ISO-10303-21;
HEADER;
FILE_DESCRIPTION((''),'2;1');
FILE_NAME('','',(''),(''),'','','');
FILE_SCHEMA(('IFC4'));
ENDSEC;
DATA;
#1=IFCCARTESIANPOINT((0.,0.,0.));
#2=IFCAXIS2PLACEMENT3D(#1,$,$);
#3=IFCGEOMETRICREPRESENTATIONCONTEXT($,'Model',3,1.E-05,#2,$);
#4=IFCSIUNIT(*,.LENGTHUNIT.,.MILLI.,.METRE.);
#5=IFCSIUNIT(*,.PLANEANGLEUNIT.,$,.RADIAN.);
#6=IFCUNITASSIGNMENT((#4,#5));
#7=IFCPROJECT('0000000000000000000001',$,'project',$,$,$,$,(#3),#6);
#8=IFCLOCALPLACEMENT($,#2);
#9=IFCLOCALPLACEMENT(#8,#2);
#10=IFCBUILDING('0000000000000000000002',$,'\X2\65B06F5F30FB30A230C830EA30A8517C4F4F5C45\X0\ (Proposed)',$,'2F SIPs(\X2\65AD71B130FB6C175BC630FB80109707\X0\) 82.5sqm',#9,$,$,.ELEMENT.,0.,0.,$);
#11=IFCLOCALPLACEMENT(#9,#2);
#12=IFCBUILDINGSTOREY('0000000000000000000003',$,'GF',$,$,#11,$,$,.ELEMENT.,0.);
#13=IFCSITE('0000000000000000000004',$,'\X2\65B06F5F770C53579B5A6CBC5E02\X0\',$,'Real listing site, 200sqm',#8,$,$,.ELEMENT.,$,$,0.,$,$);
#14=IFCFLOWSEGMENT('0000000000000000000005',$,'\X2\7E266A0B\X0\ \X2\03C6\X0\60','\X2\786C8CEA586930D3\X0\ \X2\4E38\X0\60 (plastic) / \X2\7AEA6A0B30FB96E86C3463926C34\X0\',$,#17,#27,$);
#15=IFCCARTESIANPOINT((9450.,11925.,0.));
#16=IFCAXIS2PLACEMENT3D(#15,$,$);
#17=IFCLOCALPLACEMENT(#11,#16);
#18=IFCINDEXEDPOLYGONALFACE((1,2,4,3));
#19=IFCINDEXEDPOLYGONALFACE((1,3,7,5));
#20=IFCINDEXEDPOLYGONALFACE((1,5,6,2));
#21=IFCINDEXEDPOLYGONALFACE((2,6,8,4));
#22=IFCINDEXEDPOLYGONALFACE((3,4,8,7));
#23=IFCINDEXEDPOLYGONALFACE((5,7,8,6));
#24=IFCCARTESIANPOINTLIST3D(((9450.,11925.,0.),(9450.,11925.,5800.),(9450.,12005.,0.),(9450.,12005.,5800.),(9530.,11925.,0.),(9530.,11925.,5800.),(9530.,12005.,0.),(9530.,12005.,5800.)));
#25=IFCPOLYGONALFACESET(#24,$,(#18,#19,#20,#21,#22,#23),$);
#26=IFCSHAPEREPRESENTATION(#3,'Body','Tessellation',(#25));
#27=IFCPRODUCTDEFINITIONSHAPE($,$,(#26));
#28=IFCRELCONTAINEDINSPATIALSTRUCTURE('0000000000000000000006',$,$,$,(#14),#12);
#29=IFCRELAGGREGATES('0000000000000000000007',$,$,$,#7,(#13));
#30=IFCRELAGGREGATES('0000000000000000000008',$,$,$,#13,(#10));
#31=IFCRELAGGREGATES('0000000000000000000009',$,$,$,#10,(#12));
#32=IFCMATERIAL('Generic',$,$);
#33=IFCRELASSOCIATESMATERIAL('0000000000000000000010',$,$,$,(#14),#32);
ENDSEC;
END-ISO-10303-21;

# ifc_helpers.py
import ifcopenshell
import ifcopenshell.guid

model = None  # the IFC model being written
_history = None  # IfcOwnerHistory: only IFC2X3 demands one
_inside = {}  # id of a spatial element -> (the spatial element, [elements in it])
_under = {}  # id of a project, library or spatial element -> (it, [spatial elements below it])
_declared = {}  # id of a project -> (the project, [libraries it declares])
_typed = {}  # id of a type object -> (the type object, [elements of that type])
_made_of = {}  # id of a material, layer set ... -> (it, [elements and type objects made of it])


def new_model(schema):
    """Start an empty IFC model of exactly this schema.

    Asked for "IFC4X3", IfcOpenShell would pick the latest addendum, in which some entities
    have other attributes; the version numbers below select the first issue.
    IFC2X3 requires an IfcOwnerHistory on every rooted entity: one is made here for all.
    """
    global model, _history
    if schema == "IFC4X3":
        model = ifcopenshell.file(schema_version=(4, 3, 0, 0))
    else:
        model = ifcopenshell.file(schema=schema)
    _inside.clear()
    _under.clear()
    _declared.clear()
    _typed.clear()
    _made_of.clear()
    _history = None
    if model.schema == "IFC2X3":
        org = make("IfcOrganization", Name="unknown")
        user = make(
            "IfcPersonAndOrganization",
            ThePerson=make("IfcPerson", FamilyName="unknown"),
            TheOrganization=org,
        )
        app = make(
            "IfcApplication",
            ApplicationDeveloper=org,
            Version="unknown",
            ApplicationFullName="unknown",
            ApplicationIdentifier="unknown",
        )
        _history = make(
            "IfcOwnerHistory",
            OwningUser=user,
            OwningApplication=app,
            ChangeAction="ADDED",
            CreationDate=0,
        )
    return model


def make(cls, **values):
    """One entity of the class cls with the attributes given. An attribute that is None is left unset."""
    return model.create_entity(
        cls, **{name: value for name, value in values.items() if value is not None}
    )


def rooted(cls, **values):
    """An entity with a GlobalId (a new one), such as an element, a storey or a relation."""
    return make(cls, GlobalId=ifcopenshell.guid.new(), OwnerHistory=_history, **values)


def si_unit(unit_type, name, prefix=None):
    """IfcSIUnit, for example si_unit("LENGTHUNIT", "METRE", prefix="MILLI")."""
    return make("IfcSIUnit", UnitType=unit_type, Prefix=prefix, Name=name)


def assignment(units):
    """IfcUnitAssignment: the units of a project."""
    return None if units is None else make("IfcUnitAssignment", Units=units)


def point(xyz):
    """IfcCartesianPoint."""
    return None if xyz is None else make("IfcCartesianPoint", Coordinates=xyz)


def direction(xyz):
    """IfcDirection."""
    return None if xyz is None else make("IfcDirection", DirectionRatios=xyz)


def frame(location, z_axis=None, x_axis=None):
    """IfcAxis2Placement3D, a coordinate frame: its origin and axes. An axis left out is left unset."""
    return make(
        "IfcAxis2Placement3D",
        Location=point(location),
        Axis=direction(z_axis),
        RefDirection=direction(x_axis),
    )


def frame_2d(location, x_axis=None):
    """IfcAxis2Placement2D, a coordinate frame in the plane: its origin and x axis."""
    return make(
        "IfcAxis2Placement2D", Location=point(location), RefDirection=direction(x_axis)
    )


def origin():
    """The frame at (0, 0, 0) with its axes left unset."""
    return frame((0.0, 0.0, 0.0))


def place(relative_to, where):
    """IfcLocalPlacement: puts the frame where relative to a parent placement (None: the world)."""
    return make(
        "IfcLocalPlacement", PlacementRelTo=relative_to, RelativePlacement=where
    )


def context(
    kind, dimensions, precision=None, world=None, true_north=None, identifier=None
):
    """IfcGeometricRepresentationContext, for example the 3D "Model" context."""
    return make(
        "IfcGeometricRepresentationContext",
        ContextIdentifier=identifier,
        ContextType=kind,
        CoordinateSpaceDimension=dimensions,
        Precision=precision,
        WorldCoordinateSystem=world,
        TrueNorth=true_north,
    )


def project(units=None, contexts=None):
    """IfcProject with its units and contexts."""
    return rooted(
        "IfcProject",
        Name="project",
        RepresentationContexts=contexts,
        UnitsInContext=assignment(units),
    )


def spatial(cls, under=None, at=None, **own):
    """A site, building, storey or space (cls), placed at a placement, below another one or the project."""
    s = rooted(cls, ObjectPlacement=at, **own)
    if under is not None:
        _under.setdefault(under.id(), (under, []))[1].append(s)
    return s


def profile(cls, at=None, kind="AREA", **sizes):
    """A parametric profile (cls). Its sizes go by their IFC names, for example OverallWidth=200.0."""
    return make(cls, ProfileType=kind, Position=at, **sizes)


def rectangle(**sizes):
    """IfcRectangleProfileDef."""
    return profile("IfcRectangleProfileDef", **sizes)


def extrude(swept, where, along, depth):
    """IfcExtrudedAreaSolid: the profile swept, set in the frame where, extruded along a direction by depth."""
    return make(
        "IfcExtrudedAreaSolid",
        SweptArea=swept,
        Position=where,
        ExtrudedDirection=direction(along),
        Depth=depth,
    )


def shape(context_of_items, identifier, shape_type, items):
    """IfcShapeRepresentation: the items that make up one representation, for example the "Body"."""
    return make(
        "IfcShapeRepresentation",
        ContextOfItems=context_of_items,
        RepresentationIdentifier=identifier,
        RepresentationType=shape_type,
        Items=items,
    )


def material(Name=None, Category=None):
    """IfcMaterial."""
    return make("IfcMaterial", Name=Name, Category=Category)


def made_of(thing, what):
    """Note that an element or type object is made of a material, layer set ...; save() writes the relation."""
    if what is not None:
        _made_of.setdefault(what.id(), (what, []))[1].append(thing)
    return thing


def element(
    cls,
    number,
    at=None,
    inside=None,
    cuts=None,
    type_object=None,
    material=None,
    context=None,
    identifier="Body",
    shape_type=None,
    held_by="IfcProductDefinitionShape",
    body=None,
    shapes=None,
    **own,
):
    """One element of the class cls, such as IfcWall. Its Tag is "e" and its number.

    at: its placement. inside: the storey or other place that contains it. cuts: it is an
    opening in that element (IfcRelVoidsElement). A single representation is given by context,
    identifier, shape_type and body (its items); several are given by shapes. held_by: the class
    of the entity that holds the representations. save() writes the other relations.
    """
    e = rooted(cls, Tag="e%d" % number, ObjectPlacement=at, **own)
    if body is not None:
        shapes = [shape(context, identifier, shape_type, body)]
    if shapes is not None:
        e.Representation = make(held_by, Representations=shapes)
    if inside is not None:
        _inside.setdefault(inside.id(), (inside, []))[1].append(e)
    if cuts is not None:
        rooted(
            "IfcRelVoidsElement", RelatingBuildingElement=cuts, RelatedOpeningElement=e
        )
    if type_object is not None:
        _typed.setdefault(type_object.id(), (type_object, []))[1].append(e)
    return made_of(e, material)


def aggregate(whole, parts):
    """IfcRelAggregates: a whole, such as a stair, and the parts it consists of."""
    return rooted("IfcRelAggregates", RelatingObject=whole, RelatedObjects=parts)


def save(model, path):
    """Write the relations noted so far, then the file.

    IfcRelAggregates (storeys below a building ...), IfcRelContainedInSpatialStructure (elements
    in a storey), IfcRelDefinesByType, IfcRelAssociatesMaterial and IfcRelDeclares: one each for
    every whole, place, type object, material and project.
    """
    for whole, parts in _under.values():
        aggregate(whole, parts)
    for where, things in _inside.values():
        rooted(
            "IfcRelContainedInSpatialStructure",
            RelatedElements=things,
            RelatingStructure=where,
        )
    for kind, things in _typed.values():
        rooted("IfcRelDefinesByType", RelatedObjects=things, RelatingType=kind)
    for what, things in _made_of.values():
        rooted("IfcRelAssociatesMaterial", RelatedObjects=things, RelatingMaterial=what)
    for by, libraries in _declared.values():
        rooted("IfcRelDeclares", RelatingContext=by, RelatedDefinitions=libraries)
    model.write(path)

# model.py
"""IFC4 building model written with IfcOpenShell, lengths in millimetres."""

from ifc_helpers import new_model, si_unit, frame, frame_2d, origin, place, context, project, spatial, rectangle, extrude, material, element, save


model = new_model("IFC4")

# Units and contexts
model_context = context("Model", 3, precision=1e-05, world=origin())
ifc_project = project(units=[si_unit("LENGTHUNIT", "METRE", prefix="MILLI"), si_unit("PLANEANGLEUNIT", "RADIAN")], contexts=[model_context])

# Site, building, storey
site_placement = place(None, origin())
site = spatial("IfcSite", under=ifc_project, at=site_placement, Name="新潟県南魚沼市", ObjectType="Real listing site, 200sqm", CompositionType="ELEMENT", RefElevation=0.0)
building_placement = place(site_placement, origin())
building = spatial("IfcBuilding", under=site, at=building_placement, Name="新潟・アトリエ兼住居 (Proposed)", ObjectType="2F SIPs(断熱・気密・耐震) 82.5sqm", CompositionType="ELEMENT", ElevationOfRefHeight=0.0, ElevationOfTerrain=0.0)
storey_placement = place(building_placement, origin())
storey = spatial("IfcBuildingStorey", under=building, at=storey_placement, Name="GF", CompositionType="ELEMENT", Elevation=0.0)

# Flow segment
ifc_material_1 = material(Name="Generic")
flow_segment_placement = place(storey_placement, frame((9450.0, 11925.0, 0.0)))
element("IfcFlowSegment", 1, at=flow_segment_placement, inside=storey, material=ifc_material_1, Name="縦樋 φ60", Description="硬質塩ビ 丸60 (plastic) / 竪樋・雨水排水", context=model_context, shape_type="SweptSolid", body=[
    extrude(rectangle(XDim=80.0, YDim=80.0, at=frame_2d((40.0, 40.0))), frame((9450.0, 11925.0, 0.0)), (0.0, 0.0, 1.0), 5800.0),
])

save(model, "model.ifc")
